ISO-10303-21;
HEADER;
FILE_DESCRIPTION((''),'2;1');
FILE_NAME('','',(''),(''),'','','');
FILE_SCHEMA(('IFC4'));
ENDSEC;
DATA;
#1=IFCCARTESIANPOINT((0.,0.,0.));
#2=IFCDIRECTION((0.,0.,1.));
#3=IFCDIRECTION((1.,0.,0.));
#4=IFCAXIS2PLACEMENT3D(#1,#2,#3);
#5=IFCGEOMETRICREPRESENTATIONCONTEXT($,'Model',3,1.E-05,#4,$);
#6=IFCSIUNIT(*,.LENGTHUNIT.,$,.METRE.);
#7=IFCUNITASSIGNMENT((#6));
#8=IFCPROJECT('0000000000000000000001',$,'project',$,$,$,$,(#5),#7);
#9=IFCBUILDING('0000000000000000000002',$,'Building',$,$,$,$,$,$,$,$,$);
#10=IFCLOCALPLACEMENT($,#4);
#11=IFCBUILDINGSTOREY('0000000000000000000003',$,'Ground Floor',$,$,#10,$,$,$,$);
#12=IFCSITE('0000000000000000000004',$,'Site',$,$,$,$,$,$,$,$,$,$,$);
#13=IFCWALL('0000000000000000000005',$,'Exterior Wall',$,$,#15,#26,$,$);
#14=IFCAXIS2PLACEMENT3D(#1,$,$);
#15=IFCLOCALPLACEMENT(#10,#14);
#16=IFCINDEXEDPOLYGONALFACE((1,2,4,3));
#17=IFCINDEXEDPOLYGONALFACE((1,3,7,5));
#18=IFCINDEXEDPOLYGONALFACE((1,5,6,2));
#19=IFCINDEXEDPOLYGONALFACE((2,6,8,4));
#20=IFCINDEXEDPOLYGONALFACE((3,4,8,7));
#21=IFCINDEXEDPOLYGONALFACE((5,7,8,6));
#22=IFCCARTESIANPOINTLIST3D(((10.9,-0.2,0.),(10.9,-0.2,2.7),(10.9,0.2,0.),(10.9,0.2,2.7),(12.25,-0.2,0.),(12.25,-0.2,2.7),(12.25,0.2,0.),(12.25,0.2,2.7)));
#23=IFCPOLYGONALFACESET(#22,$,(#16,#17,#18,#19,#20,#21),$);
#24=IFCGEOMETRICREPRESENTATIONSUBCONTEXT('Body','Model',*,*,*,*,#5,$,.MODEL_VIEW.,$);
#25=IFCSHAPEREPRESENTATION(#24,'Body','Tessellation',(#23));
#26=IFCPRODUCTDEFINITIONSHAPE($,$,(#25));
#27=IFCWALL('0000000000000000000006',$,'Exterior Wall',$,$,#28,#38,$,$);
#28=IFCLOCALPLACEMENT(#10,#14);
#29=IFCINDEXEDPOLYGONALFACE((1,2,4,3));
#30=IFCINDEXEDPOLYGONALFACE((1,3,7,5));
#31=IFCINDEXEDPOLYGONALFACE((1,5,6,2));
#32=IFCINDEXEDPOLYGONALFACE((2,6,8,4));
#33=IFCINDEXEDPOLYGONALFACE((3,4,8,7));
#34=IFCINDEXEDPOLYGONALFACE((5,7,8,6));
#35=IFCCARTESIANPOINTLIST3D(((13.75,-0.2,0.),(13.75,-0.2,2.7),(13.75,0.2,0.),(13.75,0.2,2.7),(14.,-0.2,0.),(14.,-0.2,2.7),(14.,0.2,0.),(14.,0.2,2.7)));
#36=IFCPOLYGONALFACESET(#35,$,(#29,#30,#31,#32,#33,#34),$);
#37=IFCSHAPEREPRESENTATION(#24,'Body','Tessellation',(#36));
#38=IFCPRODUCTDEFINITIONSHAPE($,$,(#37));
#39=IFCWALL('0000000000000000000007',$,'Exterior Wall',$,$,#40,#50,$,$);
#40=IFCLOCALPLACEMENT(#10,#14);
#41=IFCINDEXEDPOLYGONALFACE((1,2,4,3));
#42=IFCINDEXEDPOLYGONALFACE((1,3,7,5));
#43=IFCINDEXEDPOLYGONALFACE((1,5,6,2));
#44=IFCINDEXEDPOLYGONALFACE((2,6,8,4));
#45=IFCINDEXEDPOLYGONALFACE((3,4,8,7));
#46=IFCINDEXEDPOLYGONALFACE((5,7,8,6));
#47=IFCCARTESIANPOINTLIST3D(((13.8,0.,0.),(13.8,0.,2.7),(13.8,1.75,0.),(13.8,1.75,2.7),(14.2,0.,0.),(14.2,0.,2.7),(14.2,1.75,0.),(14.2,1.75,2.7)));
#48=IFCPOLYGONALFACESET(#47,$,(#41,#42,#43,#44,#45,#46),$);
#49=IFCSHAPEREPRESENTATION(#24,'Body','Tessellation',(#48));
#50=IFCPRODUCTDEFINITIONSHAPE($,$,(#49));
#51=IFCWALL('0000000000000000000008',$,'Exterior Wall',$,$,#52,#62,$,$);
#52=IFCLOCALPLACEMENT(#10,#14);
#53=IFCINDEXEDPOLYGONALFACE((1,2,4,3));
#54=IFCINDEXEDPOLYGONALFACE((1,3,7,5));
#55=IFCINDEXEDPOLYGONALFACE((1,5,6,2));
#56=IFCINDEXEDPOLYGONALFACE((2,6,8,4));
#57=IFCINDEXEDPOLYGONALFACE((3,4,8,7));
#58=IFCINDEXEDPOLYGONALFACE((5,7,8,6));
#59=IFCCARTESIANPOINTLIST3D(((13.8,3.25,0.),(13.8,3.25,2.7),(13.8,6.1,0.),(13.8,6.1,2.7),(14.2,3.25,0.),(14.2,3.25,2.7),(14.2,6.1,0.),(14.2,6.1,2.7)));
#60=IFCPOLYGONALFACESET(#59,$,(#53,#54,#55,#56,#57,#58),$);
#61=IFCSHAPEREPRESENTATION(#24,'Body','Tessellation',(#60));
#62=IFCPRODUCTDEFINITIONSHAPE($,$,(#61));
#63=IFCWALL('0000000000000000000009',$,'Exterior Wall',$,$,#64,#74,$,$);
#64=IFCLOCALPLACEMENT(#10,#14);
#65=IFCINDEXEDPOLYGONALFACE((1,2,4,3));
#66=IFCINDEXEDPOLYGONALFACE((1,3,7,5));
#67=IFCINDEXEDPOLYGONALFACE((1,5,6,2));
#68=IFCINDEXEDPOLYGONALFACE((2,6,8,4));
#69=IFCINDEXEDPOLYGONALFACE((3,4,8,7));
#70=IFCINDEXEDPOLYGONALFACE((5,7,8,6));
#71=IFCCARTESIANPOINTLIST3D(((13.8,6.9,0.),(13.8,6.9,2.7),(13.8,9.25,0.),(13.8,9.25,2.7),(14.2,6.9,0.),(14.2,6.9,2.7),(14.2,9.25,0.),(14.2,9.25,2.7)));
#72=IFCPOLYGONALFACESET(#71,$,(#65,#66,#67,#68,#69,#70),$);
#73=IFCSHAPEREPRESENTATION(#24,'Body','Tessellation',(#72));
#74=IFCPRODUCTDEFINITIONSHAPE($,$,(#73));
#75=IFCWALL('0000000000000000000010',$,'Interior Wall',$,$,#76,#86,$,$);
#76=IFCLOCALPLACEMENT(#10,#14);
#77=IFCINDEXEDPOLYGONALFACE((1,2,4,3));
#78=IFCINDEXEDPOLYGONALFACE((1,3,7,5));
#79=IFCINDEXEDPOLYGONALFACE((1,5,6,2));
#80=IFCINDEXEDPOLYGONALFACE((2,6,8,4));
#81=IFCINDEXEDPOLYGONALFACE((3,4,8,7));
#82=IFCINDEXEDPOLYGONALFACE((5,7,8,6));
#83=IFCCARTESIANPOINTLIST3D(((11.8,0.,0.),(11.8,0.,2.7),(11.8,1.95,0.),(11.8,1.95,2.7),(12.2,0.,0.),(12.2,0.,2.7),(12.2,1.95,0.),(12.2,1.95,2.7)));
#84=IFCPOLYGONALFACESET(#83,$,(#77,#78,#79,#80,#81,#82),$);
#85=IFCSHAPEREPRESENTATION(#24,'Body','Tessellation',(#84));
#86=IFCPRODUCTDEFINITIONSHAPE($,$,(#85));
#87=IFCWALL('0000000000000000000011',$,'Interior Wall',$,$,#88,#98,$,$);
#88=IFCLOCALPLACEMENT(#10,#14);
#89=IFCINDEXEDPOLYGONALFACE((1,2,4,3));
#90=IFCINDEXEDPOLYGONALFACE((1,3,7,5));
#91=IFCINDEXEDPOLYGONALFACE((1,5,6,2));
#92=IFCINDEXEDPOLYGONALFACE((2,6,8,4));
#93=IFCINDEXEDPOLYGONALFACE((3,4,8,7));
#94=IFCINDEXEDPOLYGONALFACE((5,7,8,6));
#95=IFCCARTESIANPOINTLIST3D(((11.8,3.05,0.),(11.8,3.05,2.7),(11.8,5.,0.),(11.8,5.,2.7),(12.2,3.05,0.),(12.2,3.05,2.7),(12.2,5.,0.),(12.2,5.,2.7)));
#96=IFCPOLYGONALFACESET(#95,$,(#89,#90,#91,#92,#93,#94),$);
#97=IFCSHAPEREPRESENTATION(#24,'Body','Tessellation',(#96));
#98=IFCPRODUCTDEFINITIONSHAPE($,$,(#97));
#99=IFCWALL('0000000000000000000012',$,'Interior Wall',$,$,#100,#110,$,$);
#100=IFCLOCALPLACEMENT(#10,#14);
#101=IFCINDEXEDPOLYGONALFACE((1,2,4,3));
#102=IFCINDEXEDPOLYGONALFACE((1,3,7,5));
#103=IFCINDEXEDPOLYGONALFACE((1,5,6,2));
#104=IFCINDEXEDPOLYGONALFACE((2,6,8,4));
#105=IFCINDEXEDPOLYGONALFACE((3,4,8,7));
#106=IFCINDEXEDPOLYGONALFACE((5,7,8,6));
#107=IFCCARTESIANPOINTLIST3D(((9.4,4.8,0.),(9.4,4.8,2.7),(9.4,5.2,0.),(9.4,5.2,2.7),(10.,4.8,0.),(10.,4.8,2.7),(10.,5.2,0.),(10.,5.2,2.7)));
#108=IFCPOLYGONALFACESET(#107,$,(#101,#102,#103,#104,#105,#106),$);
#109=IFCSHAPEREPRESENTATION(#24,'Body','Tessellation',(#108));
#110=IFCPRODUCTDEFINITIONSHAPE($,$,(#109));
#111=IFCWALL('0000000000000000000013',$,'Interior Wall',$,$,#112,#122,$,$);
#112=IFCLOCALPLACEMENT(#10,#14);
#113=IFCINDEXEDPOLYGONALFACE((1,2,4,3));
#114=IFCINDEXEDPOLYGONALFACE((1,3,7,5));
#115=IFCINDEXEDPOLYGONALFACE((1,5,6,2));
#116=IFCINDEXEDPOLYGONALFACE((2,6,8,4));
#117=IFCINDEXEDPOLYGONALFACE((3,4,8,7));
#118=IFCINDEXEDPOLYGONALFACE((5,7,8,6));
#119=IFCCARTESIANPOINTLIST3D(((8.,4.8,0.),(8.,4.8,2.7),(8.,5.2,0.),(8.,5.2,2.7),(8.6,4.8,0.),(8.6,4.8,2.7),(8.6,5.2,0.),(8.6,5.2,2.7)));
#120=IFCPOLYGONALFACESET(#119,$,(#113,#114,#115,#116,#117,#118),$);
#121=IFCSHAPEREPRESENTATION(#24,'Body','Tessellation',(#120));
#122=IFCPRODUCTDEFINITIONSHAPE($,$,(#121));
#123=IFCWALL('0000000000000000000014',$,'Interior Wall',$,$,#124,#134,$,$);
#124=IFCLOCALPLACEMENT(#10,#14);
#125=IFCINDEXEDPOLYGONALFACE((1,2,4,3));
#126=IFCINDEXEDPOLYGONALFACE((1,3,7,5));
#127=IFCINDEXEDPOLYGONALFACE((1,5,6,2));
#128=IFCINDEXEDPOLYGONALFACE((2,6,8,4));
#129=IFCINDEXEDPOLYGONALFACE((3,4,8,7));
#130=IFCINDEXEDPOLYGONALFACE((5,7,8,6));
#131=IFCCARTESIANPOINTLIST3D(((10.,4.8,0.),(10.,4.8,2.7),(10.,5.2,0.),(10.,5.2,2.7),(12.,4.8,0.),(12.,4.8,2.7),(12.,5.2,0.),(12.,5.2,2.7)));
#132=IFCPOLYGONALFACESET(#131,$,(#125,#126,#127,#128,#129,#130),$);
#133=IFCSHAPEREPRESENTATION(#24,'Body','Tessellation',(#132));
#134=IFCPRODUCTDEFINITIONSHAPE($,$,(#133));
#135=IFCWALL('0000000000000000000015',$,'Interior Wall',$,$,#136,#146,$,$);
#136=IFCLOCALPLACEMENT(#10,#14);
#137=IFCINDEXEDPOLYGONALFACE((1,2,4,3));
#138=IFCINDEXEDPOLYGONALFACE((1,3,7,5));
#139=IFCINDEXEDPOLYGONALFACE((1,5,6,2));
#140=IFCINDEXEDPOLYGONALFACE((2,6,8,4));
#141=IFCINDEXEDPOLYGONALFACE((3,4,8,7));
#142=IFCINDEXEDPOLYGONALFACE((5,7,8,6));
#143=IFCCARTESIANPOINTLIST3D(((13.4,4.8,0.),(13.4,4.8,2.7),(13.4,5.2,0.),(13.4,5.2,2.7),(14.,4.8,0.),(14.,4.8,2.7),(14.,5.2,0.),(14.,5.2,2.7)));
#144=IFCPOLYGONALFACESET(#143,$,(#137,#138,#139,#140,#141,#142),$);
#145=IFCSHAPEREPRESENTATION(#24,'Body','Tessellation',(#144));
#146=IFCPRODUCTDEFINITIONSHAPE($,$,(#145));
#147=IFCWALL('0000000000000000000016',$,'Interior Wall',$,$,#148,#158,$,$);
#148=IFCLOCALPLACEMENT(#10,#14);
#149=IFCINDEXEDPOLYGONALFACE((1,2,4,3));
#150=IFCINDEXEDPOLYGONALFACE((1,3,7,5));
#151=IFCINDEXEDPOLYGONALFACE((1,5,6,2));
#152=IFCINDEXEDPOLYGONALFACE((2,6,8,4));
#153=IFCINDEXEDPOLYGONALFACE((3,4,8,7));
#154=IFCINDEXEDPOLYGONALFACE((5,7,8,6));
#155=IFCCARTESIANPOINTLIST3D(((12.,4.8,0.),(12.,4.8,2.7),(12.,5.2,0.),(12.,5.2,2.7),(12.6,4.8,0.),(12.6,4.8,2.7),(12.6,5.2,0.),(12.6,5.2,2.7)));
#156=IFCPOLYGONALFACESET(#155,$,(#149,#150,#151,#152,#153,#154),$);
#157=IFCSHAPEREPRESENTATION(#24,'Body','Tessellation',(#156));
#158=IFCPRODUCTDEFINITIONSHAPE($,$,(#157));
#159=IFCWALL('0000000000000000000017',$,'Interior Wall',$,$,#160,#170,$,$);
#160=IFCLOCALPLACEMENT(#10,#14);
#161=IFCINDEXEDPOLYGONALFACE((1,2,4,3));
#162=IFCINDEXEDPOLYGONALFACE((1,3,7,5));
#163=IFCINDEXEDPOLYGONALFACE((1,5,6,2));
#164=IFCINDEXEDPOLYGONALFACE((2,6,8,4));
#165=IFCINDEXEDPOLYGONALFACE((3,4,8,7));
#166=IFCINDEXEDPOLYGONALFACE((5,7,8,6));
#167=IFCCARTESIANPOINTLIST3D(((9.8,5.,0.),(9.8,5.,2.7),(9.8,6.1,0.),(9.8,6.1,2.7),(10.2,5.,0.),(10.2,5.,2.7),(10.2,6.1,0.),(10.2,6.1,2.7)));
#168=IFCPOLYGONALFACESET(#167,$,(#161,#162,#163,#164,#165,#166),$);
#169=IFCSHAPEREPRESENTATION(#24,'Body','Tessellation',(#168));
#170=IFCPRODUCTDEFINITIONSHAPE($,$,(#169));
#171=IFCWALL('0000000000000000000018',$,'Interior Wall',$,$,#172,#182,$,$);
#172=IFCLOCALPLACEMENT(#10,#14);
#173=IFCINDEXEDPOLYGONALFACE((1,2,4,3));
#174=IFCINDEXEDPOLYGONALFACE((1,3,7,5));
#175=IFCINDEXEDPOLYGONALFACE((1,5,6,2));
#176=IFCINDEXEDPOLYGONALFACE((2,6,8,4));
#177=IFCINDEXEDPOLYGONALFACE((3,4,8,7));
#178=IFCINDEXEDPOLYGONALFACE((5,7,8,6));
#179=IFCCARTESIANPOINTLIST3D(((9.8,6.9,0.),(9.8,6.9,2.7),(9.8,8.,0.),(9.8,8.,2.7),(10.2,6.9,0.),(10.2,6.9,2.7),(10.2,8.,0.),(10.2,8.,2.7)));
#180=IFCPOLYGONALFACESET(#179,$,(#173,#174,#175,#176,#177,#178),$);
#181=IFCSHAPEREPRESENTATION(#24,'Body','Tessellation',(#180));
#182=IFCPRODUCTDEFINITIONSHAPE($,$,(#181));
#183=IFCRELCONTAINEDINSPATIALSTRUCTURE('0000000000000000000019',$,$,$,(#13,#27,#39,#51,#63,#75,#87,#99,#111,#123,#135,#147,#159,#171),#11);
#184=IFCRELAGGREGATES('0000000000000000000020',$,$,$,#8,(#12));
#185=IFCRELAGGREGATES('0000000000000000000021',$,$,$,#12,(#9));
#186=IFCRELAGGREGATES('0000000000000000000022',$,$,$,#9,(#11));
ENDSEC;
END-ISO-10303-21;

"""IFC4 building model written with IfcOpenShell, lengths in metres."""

from ifc_helpers import new_model, si_unit, frame, origin_with_axes, place, context, subcontext, project, spatial, indexed_curve, outline, extrude, element, save


model = new_model("IFC4")

# Units and contexts
model_context = context("Model", 3, precision=1e-05, world=origin_with_axes())
body_context = subcontext(model_context, "Body", "Model", "MODEL_VIEW")
ifc_project = project(units=[si_unit("LENGTHUNIT", "METRE")], contexts=[model_context])

# Site, building, storey
site = spatial("IfcSite", under=ifc_project, Name="Site")
building = spatial("IfcBuilding", under=site, Name="Building")
storey_placement = place(None, origin_with_axes())
storey = spatial("IfcBuildingStorey", under=building, at=storey_placement, Name="Ground Floor")

# Walls
wall_1_placement = place(storey_placement, frame((10.9, 0.0, 0.0), z_axis=(0.0, 0.0, 1.0), x_axis=(1.0, 0.0, 0.0)))
element("IfcWall", 1, at=wall_1_placement, inside=storey, Name="Exterior Wall", context=body_context, shape_type="SweptSolid", body=[
    extrude(outline(indexed_curve([(0.0, 0.0), (0.0, 0.4), (1.35, 0.4), (1.35, 0.0), (0.0, 0.0)], self_intersect=False)), frame((0.0, -0.2, 0.0), z_axis=(0.0, 0.0, 1.0), x_axis=(1.0, 0.0, 0.0)), (0.0, 0.0, 1.0), 2.7),
])
wall_2_placement = place(storey_placement, frame((13.75, 0.0, 0.0), z_axis=(0.0, 0.0, 1.0), x_axis=(1.0, 0.0, 0.0)))
element("IfcWall", 2, at=wall_2_placement, inside=storey, Name="Exterior Wall", context=body_context, shape_type="SweptSolid", body=[
    extrude(outline(indexed_curve([(0.0, 0.0), (0.0, 0.4), (0.25, 0.4), (0.25, 0.0), (0.0, 0.0)], self_intersect=False)), frame((0.0, -0.2, 0.0), z_axis=(0.0, 0.0, 1.0), x_axis=(1.0, 0.0, 0.0)), (0.0, 0.0, 1.0), 2.7),
])
wall_3_placement = place(storey_placement, frame((14.0, 0.0, 0.0), z_axis=(0.0, 0.0, 1.0), x_axis=(0.0, 1.0, 0.0)))
element("IfcWall", 3, at=wall_3_placement, inside=storey, Name="Exterior Wall", context=body_context, shape_type="SweptSolid", body=[
    extrude(outline(indexed_curve([(0.0, 0.0), (0.0, 0.4), (1.75, 0.4), (1.75, 0.0), (0.0, 0.0)], self_intersect=False)), frame((0.0, -0.2, 0.0), z_axis=(0.0, 0.0, 1.0), x_axis=(1.0, 0.0, 0.0)), (0.0, 0.0, 1.0), 2.7),
])
wall_4_placement = place(storey_placement, frame((14.0, 3.25, 0.0), z_axis=(0.0, 0.0, 1.0), x_axis=(0.0, 1.0, 0.0)))
element("IfcWall", 4, at=wall_4_placement, inside=storey, Name="Exterior Wall", context=body_context, shape_type="SweptSolid", body=[
    extrude(outline(indexed_curve([(0.0, 0.0), (0.0, 0.4), (2.85, 0.4), (2.85, 0.0), (0.0, 0.0)], self_intersect=False)), frame((0.0, -0.2, 0.0), z_axis=(0.0, 0.0, 1.0), x_axis=(1.0, 0.0, 0.0)), (0.0, 0.0, 1.0), 2.7),
])
wall_5_placement = place(storey_placement, frame((14.0, 6.9, 0.0), z_axis=(0.0, 0.0, 1.0), x_axis=(0.0, 1.0, 0.0)))
element("IfcWall", 5, at=wall_5_placement, inside=storey, Name="Exterior Wall", context=body_context, shape_type="SweptSolid", body=[
    extrude(outline(indexed_curve([(0.0, 0.0), (0.0, 0.4), (2.35, 0.4), (2.35, 0.0), (0.0, 0.0)], self_intersect=False)), frame((0.0, -0.2, 0.0), z_axis=(0.0, 0.0, 1.0), x_axis=(1.0, 0.0, 0.0)), (0.0, 0.0, 1.0), 2.7),
])
wall_6_placement = place(storey_placement, frame((12.0, 0.0, 0.0), z_axis=(0.0, 0.0, 1.0), x_axis=(0.0, 1.0, 0.0)))
element("IfcWall", 6, at=wall_6_placement, inside=storey, Name="Interior Wall", context=body_context, shape_type="SweptSolid", body=[
    extrude(outline(indexed_curve([(0.0, 0.0), (0.0, 0.4), (1.95, 0.4), (1.95, 0.0), (0.0, 0.0)], self_intersect=False)), frame((0.0, -0.2, 0.0), z_axis=(0.0, 0.0, 1.0), x_axis=(1.0, 0.0, 0.0)), (0.0, 0.0, 1.0), 2.7),
])
wall_7_placement = place(storey_placement, frame((12.0, 3.05, 0.0), z_axis=(0.0, 0.0, 1.0), x_axis=(0.0, 1.0, 0.0)))
element("IfcWall", 7, at=wall_7_placement, inside=storey, Name="Interior Wall", context=body_context, shape_type="SweptSolid", body=[
    extrude(outline(indexed_curve([(0.0, 0.0), (0.0, 0.4), (1.95, 0.4), (1.95, 0.0), (0.0, 0.0)], self_intersect=False)), frame((0.0, -0.2, 0.0), z_axis=(0.0, 0.0, 1.0), x_axis=(1.0, 0.0, 0.0)), (0.0, 0.0, 1.0), 2.7),
])
for number, where, z_axis, x_axis, name in (
    (8, (10.0, 5.0, 0.0), (0.0, 0.0, 1.0), (-1.0, 0.0, 0.0), "Interior Wall"),
    (9, (8.6, 5.0, 0.0), (0.0, 0.0, 1.0), (-1.0, 0.0, 0.0), "Interior Wall"),
):
    element("IfcWall", number, at=place(storey_placement, frame(where, z_axis=z_axis, x_axis=x_axis)), inside=storey, Name=name, context=body_context, shape_type="SweptSolid", body=[
        extrude(outline(indexed_curve([(0.0, 0.0), (0.0, 0.4), (0.6, 0.4), (0.6, 0.0), (0.0, 0.0)], self_intersect=False)), frame((0.0, -0.2, 0.0), z_axis=(0.0, 0.0, 1.0), x_axis=(1.0, 0.0, 0.0)), (0.0, 0.0, 1.0), 2.7),
    ])
wall_8_placement = place(storey_placement, frame((12.0, 5.0, 0.0), z_axis=(0.0, 0.0, 1.0), x_axis=(-1.0, 0.0, 0.0)))
element("IfcWall", 10, at=wall_8_placement, inside=storey, Name="Interior Wall", context=body_context, shape_type="SweptSolid", body=[
    extrude(outline(indexed_curve([(0.0, 0.0), (0.0, 0.4), (2.0, 0.4), (2.0, 0.0), (0.0, 0.0)], self_intersect=False)), frame((0.0, -0.2, 0.0), z_axis=(0.0, 0.0, 1.0), x_axis=(1.0, 0.0, 0.0)), (0.0, 0.0, 1.0), 2.7),
])
for number, where, z_axis, x_axis, name in (
    (11, (14.0, 5.0, 0.0), (0.0, 0.0, 1.0), (-1.0, 0.0, 0.0), "Interior Wall"),
    (12, (12.6, 5.0, 0.0), (0.0, 0.0, 1.0), (-1.0, 0.0, 0.0), "Interior Wall"),
):
    element("IfcWall", number, at=place(storey_placement, frame(where, z_axis=z_axis, x_axis=x_axis)), inside=storey, Name=name, context=body_context, shape_type="SweptSolid", body=[
        extrude(outline(indexed_curve([(0.0, 0.0), (0.0, 0.4), (0.6, 0.4), (0.6, 0.0), (0.0, 0.0)], self_intersect=False)), frame((0.0, -0.2, 0.0), z_axis=(0.0, 0.0, 1.0), x_axis=(1.0, 0.0, 0.0)), (0.0, 0.0, 1.0), 2.7),
    ])
for number, where, z_axis, x_axis, name in (
    (13, (10.0, 5.0, 0.0), (0.0, 0.0, 1.0), (0.0, 1.0, 0.0), "Interior Wall"),
    (14, (10.0, 6.9, 0.0), (0.0, 0.0, 1.0), (0.0, 1.0, 0.0), "Interior Wall"),
):
    element("IfcWall", number, at=place(storey_placement, frame(where, z_axis=z_axis, x_axis=x_axis)), inside=storey, Name=name, context=body_context, shape_type="SweptSolid", body=[
        extrude(outline(indexed_curve([(0.0, 0.0), (0.0, 0.4), (1.1, 0.4), (1.1, 0.0), (0.0, 0.0)], self_intersect=False)), frame((0.0, -0.2, 0.0), z_axis=(0.0, 0.0, 1.0), x_axis=(1.0, 0.0, 0.0)), (0.0, 0.0, 1.0), 2.7),
    ])

save(model, "model.ifc")
